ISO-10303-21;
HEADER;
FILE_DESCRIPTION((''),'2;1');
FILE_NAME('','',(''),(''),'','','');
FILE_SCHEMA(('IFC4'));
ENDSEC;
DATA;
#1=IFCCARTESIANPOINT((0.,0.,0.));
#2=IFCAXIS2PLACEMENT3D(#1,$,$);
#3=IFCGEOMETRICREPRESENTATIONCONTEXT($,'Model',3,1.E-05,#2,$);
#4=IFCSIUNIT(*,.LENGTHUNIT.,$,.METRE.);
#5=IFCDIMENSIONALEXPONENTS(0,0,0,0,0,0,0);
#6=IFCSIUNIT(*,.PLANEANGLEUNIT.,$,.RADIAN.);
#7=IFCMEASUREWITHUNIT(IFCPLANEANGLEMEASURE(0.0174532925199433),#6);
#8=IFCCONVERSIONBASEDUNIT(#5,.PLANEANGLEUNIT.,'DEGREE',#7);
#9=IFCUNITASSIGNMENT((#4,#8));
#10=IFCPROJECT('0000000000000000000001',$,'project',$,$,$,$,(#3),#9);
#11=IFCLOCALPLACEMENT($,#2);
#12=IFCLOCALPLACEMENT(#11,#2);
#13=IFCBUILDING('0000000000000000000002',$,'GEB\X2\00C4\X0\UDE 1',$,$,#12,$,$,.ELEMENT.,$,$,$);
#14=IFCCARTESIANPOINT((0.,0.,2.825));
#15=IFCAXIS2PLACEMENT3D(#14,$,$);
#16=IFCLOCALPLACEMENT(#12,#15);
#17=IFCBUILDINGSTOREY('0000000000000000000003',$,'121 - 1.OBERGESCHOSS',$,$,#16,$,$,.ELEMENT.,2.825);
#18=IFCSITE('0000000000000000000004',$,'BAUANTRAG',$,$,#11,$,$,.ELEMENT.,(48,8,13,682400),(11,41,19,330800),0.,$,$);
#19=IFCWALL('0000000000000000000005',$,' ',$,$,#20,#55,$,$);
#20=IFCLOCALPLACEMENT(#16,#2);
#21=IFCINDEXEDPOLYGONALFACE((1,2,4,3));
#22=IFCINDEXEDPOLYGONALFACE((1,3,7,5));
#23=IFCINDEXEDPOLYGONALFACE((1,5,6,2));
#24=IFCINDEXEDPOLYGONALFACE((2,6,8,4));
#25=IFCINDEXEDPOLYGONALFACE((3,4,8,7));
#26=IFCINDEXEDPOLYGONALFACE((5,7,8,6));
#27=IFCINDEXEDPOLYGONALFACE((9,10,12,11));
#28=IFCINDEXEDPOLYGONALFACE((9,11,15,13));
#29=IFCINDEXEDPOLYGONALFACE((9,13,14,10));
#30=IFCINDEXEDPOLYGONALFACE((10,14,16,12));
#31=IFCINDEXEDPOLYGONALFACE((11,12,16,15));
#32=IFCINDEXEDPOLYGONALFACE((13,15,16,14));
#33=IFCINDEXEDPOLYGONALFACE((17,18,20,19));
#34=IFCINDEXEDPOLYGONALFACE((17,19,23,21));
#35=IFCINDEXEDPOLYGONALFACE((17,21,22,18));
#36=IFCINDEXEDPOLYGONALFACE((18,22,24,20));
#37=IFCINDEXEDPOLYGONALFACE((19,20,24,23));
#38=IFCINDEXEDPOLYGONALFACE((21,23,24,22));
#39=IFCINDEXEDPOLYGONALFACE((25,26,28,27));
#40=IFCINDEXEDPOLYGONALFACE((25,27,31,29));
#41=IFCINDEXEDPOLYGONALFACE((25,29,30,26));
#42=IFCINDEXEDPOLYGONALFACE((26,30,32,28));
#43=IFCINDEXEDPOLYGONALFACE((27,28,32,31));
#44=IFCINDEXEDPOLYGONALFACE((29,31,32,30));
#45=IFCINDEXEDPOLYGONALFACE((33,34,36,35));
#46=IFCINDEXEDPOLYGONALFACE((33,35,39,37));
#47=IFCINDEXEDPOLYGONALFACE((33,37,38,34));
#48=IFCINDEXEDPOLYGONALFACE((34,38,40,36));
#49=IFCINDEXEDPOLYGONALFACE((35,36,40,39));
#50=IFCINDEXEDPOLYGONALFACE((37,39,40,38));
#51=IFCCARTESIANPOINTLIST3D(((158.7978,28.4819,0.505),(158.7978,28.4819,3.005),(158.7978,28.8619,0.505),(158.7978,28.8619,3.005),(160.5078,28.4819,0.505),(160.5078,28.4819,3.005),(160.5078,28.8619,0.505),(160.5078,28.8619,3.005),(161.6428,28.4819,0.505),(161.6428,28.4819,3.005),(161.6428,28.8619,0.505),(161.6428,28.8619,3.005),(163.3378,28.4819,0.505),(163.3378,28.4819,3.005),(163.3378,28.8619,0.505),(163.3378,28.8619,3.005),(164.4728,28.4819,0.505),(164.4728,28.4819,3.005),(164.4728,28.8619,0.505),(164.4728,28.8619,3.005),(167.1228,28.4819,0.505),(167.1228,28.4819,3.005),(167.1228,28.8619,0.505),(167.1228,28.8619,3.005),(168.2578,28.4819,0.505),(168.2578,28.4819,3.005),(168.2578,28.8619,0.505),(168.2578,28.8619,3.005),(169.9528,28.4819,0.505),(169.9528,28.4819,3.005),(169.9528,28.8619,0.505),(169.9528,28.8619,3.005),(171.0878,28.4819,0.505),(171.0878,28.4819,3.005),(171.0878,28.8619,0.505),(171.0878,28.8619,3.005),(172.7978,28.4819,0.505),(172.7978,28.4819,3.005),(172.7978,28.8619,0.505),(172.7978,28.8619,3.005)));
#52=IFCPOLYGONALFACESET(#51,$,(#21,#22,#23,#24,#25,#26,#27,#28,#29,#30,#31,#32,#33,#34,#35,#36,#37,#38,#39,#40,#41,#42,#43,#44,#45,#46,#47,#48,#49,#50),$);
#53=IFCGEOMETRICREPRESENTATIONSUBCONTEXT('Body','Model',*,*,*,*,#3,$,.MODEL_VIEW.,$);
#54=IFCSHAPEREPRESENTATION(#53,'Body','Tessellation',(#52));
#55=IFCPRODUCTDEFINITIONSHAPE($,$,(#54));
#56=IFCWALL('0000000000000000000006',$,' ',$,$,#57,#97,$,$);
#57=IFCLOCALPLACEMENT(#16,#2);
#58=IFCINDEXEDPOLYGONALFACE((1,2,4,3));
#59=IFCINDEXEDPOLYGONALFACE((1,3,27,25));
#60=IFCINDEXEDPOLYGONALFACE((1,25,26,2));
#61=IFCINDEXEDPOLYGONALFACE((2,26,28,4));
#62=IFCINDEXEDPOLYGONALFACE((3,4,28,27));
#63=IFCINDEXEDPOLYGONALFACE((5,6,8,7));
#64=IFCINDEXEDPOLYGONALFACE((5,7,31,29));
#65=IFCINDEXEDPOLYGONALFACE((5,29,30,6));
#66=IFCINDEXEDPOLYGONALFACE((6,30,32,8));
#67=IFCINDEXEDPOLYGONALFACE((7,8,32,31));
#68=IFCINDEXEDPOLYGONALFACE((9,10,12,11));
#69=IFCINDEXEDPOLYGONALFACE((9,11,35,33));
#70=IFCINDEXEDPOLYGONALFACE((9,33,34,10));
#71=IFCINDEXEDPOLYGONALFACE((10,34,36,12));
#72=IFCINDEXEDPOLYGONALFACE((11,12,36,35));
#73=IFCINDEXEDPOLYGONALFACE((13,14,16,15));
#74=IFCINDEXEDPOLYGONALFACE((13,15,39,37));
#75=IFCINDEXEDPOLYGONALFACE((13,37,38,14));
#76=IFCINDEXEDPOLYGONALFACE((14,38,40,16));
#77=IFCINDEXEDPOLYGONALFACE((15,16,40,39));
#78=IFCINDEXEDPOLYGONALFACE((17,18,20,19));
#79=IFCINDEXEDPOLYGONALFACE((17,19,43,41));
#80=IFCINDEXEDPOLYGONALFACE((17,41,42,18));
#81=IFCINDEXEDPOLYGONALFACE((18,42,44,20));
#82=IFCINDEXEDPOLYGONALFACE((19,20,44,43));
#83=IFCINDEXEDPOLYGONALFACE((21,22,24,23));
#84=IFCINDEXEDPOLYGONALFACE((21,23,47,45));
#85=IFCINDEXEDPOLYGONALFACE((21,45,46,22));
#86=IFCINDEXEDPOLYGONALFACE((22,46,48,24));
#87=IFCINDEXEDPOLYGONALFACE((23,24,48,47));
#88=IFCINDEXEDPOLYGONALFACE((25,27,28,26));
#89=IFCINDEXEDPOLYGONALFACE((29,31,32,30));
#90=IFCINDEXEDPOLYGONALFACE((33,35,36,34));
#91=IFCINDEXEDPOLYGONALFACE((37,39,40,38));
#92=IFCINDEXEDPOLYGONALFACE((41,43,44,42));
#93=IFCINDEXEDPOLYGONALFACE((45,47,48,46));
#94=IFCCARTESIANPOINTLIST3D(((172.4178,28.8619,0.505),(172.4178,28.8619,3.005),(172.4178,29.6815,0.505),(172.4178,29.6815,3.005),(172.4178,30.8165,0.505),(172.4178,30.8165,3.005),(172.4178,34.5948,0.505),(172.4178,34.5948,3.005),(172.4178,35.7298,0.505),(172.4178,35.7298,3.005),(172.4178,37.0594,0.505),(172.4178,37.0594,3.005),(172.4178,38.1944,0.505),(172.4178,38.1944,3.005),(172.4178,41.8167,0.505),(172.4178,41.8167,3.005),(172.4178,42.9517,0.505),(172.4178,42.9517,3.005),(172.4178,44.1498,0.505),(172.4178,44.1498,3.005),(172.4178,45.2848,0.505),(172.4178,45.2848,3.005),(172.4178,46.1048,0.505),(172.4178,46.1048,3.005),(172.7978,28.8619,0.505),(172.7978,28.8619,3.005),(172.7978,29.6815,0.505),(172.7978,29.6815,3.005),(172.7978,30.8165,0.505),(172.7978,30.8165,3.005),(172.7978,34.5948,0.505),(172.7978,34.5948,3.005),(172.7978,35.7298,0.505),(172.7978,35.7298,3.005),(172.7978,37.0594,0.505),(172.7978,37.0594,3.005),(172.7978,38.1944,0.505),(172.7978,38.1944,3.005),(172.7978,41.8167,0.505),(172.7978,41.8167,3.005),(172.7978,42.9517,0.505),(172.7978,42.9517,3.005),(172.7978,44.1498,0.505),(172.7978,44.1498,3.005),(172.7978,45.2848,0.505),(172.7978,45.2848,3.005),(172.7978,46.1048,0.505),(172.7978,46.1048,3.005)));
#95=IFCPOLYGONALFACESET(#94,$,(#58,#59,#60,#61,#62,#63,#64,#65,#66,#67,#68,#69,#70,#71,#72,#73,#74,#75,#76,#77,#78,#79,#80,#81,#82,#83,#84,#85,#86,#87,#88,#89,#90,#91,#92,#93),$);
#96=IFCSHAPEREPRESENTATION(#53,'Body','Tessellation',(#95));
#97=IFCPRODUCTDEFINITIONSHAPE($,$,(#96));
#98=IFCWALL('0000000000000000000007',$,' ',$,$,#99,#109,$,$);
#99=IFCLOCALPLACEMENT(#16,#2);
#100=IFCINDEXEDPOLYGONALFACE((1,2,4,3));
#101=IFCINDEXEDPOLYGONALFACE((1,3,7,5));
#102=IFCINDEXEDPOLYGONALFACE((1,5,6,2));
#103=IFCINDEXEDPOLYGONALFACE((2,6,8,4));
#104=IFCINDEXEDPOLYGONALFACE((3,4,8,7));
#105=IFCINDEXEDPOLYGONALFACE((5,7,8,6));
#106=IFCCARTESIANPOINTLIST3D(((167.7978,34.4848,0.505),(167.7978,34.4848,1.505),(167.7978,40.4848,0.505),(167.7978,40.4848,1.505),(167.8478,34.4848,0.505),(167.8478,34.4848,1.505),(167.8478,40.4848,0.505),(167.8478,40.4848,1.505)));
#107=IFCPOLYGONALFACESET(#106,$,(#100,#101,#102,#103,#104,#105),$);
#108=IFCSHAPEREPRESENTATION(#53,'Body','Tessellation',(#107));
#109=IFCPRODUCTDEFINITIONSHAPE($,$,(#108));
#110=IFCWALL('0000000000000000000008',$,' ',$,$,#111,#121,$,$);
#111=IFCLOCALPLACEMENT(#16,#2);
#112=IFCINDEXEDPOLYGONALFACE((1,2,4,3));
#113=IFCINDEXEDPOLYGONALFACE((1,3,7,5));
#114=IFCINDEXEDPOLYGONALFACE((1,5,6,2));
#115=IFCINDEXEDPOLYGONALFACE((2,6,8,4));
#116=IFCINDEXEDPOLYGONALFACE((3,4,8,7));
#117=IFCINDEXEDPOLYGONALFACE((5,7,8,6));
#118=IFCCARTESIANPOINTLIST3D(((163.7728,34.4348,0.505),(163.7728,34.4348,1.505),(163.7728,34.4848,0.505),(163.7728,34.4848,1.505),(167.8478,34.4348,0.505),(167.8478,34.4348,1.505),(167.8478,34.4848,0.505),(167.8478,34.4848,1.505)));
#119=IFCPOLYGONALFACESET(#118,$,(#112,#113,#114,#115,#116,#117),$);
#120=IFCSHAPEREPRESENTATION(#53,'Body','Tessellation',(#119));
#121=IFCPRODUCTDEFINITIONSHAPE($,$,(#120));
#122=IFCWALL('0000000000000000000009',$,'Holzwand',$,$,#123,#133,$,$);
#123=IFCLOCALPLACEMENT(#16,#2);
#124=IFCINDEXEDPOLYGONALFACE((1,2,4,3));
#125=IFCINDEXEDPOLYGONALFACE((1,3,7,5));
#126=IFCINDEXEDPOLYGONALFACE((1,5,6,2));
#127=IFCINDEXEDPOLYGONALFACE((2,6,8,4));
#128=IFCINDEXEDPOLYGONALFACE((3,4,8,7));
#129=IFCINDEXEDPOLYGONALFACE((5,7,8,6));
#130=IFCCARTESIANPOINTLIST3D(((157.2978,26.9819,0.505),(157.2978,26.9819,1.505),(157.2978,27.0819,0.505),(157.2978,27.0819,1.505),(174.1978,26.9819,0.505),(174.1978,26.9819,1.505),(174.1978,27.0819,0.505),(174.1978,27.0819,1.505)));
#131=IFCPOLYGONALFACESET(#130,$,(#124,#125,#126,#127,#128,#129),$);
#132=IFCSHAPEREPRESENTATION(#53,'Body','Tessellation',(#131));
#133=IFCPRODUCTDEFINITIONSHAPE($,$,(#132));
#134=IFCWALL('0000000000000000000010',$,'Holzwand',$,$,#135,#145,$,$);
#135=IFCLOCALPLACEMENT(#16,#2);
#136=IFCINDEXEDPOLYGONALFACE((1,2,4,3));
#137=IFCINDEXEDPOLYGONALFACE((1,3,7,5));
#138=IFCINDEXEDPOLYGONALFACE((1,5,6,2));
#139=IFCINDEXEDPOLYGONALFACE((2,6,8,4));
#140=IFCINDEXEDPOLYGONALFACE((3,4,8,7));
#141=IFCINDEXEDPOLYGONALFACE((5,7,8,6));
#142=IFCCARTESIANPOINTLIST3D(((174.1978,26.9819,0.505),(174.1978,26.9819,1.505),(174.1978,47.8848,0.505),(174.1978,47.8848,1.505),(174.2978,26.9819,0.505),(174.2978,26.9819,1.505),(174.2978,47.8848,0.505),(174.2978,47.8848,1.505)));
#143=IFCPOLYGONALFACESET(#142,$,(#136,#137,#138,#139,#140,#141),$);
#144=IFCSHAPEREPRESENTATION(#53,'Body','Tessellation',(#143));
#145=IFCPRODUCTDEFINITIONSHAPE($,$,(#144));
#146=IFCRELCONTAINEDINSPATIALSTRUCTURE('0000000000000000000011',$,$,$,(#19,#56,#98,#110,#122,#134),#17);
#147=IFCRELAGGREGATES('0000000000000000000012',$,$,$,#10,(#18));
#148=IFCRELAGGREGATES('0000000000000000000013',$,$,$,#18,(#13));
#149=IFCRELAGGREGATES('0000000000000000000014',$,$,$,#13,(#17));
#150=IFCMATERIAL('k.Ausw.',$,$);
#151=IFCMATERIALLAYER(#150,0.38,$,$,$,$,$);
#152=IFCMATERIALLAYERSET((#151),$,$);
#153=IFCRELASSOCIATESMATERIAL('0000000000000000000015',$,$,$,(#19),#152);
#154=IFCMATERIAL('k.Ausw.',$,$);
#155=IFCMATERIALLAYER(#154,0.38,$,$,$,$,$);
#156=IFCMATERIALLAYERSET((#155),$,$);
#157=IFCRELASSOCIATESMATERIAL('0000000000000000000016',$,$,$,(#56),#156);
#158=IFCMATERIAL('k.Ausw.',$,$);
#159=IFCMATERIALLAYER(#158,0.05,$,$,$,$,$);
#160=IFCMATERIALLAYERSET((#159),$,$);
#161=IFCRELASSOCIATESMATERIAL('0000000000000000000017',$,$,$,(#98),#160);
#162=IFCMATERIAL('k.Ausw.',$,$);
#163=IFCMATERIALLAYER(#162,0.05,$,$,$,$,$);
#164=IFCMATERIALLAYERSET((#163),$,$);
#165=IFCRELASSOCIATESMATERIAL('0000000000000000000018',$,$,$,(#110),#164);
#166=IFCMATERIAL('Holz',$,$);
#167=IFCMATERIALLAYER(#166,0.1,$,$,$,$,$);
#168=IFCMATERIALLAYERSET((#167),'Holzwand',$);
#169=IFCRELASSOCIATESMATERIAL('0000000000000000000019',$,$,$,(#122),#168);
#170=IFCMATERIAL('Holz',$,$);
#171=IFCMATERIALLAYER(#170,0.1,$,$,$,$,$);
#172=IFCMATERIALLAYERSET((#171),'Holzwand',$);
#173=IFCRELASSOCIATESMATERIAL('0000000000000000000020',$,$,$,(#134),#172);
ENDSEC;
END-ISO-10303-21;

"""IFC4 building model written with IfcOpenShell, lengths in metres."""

from ifc_helpers import new_model, entity, si_unit, converted_unit, frame, frame_2d, origin, origin_with_axes, place, context, subcontext, project, spatial, polyline, rectangle, outline, extrude, material, layer, layer_set, layer_usage, element, save


model = new_model("IFC4")

# Units and contexts
model_context = context("Model", 3, precision=1e-05, world=origin())
body_context = subcontext(model_context, "Body", "Model", "MODEL_VIEW")
ifc_project = project(units=[si_unit("LENGTHUNIT", "METRE"), converted_unit("PLANEANGLEUNIT", "DEGREE", entity("IfcPlaneAngleMeasure", 0.0174532925199433), si_unit("PLANEANGLEUNIT", "RADIAN"), dimensions=[0, 0, 0, 0, 0, 0, 0])], contexts=[model_context])

# Site, building, storey
site_placement = place(None, origin())
site = spatial("IfcSite", under=ifc_project, at=site_placement, Name="BAUANTRAG", CompositionType="ELEMENT", RefLatitude=(48, 8, 13, 682400), RefLongitude=(11, 41, 19, 330800), RefElevation=0.0)
building_placement = place(site_placement, origin())
building = spatial("IfcBuilding", under=site, at=building_placement, Name="GEBÄUDE 1", CompositionType="ELEMENT")
storey_placement = place(building_placement, frame((0.0, 0.0, 2.825)))
storey = spatial("IfcBuildingStorey", under=building, at=storey_placement, Name="121 - 1.OBERGESCHOSS", CompositionType="ELEMENT", Elevation=2.825)

# Walls, openings
ifc_material_1 = material(Name="k.Ausw.")
ifc_layer_1 = layer(ifc_material_1, 0.38)
ifc_layer_set_1 = layer_set([ifc_layer_1])
ifc_layer_usage_1 = layer_usage(ifc_layer_set_1, "AXIS2", "POSITIVE", 0.0)
wall_1_placement = place(storey_placement, frame((158.7978, 28.4819, 0.505), z_axis=(0.0, 0.0, 1.0), x_axis=(1.0, 0.0, 0.0)))
wall_1 = element("IfcWall", 1, at=wall_1_placement, inside=storey, material=ifc_layer_usage_1, Name=" ", context=body_context, shape_type="SweptSolid", body=[
    extrude(rectangle(XDim=14.0, YDim=0.38, at=frame_2d((7.0, 0.19), x_axis=(1.0, 0.0))), origin_with_axes(), (0.0, 0.0, 1.0), 2.5),
])
opening_1_placement = place(wall_1_placement, frame((5.675, 0.38, 0.0), z_axis=(0.0, -1.0, 0.0), x_axis=(0.0, 0.0, 1.0)))
element("IfcOpeningElement", 2, at=opening_1_placement, cuts=wall_1, ObjectType="Opening", context=body_context, shape_type="SweptSolid", body=[
    extrude(outline(polyline([(0.0, 1.135), (2.5, 1.135), (2.5, 0.0), (0.0, 0.0), (0.0, 1.135)])), origin_with_axes(), (0.0, 0.0, 1.0), 0.38),
])
opening_2_placement = place(wall_1_placement, frame((9.46, 0.38, 0.0), z_axis=(0.0, -1.0, 0.0), x_axis=(0.0, 0.0, 1.0)))
element("IfcOpeningElement", 3, at=opening_2_placement, cuts=wall_1, ObjectType="Opening", context=body_context, shape_type="SweptSolid", body=[
    extrude(outline(polyline([(0.0, 1.135), (2.5, 1.135), (2.5, 0.0), (0.0, 0.0), (0.0, 1.135)])), origin_with_axes(), (0.0, 0.0, 1.0), 0.38),
])
opening_3_placement = place(wall_1_placement, frame((2.845, 0.38, 0.0), z_axis=(0.0, -1.0, 0.0), x_axis=(0.0, 0.0, 1.0)))
element("IfcOpeningElement", 4, at=opening_3_placement, cuts=wall_1, ObjectType="Opening", context=body_context, shape_type="SweptSolid", body=[
    extrude(outline(polyline([(0.0, 1.135), (2.5, 1.135), (2.5, 0.0), (0.0, 0.0), (0.0, 1.135)])), origin_with_axes(), (0.0, 0.0, 1.0), 0.38),
])
opening_4_placement = place(wall_1_placement, frame((12.29, 0.38, 0.0), z_axis=(0.0, -1.0, 0.0), x_axis=(0.0, 0.0, 1.0)))
element("IfcOpeningElement", 5, at=opening_4_placement, cuts=wall_1, ObjectType="Opening", context=body_context, shape_type="SweptSolid", body=[
    extrude(outline(polyline([(0.0, 1.135), (2.5, 1.135), (2.5, 0.0), (0.0, 0.0), (0.0, 1.135)])), origin_with_axes(), (0.0, 0.0, 1.0), 0.38),
])
ifc_material_2 = material(Name="k.Ausw.")
ifc_layer_2 = layer(ifc_material_2, 0.38)
ifc_layer_set_2 = layer_set([ifc_layer_2])
ifc_layer_usage_2 = layer_usage(ifc_layer_set_2, "AXIS2", "POSITIVE", 0.0)
wall_2_placement = place(storey_placement, frame((172.7978, 28.8619, 0.505), z_axis=(0.0, 0.0, 1.0), x_axis=(0.0, 1.0, 0.0)))
wall_2 = element("IfcWall", 6, at=wall_2_placement, inside=storey, material=ifc_layer_usage_2, Name=" ", context=body_context, shape_type="SweptSolid", body=[
    extrude(rectangle(XDim=17.2429, YDim=0.38, at=frame_2d((8.6214, 0.19), x_axis=(1.0, 0.0))), origin_with_axes(), (0.0, 0.0, 1.0), 2.5),
])
opening_5_placement = place(wall_2_placement, frame((9.3325, 0.38, 0.0), z_axis=(0.0, -1.0, 0.0), x_axis=(0.0, 0.0, 1.0)))
element("IfcOpeningElement", 7, at=opening_5_placement, cuts=wall_2, ObjectType="Opening", context=body_context, shape_type="SweptSolid", body=[
    extrude(outline(polyline([(0.0, 1.135), (2.5, 1.135), (2.5, 0.0), (0.0, 0.0), (0.0, 1.135)])), origin_with_axes(), (0.0, 0.0, 1.0), 0.38),
])
opening_6_placement = place(wall_2_placement, frame((6.8679, 0.38, 0.0), z_axis=(0.0, -1.0, 0.0), x_axis=(0.0, 0.0, 1.0)))
element("IfcOpeningElement", 8, at=opening_6_placement, cuts=wall_2, ObjectType="Opening", context=body_context, shape_type="SweptSolid", body=[
    extrude(outline(polyline([(0.0, 1.135), (2.5, 1.135), (2.5, 0.0), (0.0, 0.0), (0.0, 1.135)])), origin_with_axes(), (0.0, 0.0, 1.0), 0.38),
])
opening_7_placement = place(wall_2_placement, frame((1.9546, 0.38, 0.0), z_axis=(0.0, -1.0, 0.0), x_axis=(0.0, 0.0, 1.0)))
element("IfcOpeningElement", 9, at=opening_7_placement, cuts=wall_2, ObjectType="Opening", context=body_context, shape_type="SweptSolid", body=[
    extrude(outline(polyline([(0.0, 1.135), (2.5, 1.135), (2.5, 0.0), (0.0, 0.0), (0.0, 1.135)])), origin_with_axes(), (0.0, 0.0, 1.0), 0.38),
])
opening_8_placement = place(wall_2_placement, frame((16.4229, 0.38, 0.0), z_axis=(0.0, -1.0, 0.0), x_axis=(0.0, 0.0, 1.0)))
element("IfcOpeningElement", 10, at=opening_8_placement, cuts=wall_2, ObjectType="Opening", context=body_context, shape_type="SweptSolid", body=[
    extrude(outline(polyline([(0.0, 1.135), (2.5, 1.135), (2.5, 0.0), (0.0, 0.0), (0.0, 1.135)])), origin_with_axes(), (0.0, 0.0, 1.0), 0.38),
])
opening_9_placement = place(wall_2_placement, frame((14.0898, 0.38, 0.0), z_axis=(0.0, -1.0, 0.0), x_axis=(0.0, 0.0, 1.0)))
element("IfcOpeningElement", 11, at=opening_9_placement, cuts=wall_2, ObjectType="Opening", context=body_context, shape_type="SweptSolid", body=[
    extrude(outline(polyline([(0.0, 1.135), (2.5, 1.135), (2.5, 0.0), (0.0, 0.0), (0.0, 1.135)])), origin_with_axes(), (0.0, 0.0, 1.0), 0.38),
])

# Walls
ifc_material_3 = material(Name="k.Ausw.")
ifc_layer_3 = layer(ifc_material_3, 0.05)
ifc_layer_set_3 = layer_set([ifc_layer_3])
ifc_layer_usage_3 = layer_usage(ifc_layer_set_3, "AXIS2", "POSITIVE", 0.0)
wall_3_placement = place(storey_placement, frame((167.8478, 34.4848, 0.505), z_axis=(0.0, 0.0, 1.0), x_axis=(0.0, 1.0, 0.0)))
element("IfcWall", 12, at=wall_3_placement, inside=storey, material=ifc_layer_usage_3, Name=" ", context=body_context, shape_type="SweptSolid", body=[
    extrude(rectangle(XDim=6.0, YDim=0.05, at=frame_2d((3.0, 0.025), x_axis=(1.0, 0.0))), origin_with_axes(), (0.0, 0.0, 1.0), 1.0),
])
ifc_material_4 = material(Name="k.Ausw.")
ifc_layer_4 = layer(ifc_material_4, 0.05)
ifc_layer_set_4 = layer_set([ifc_layer_4])
ifc_layer_usage_4 = layer_usage(ifc_layer_set_4, "AXIS2", "POSITIVE", 0.0)
wall_4_placement = place(storey_placement, frame((163.7728, 34.4348, 0.505), z_axis=(0.0, 0.0, 1.0), x_axis=(1.0, 0.0, 0.0)))
element("IfcWall", 13, at=wall_4_placement, inside=storey, material=ifc_layer_usage_4, Name=" ", context=body_context, shape_type="SweptSolid", body=[
    extrude(rectangle(XDim=4.075, YDim=0.05, at=frame_2d((2.0375, 0.025), x_axis=(1.0, 0.0))), origin_with_axes(), (0.0, 0.0, 1.0), 1.0),
])
ifc_material_5 = material(Name="Holz")
ifc_layer_5 = layer(ifc_material_5, 0.1)
ifc_layer_set_5 = layer_set([ifc_layer_5], Name="Holzwand")
ifc_layer_usage_5 = layer_usage(ifc_layer_set_5, "AXIS2", "POSITIVE", 0.0)
wall_5_placement = place(storey_placement, frame((157.2978, 26.9819, 0.505)))
element("IfcWall", 14, at=wall_5_placement, inside=storey, material=ifc_layer_usage_5, Name="Holzwand", context=body_context, shape_type="SweptSolid", body=[
    extrude(rectangle(XDim=16.9, YDim=0.1, at=frame_2d((8.45, 0.05), x_axis=(1.0, 0.0))), origin_with_axes(), (0.0, 0.0, 1.0), 1.0),
])
ifc_material_6 = material(Name="Holz")
ifc_layer_6 = layer(ifc_material_6, 0.1)
ifc_layer_set_6 = layer_set([ifc_layer_6], Name="Holzwand")
ifc_layer_usage_6 = layer_usage(ifc_layer_set_6, "AXIS2", "POSITIVE", 0.0)
wall_6_placement = place(storey_placement, frame((174.2978, 26.9819, 0.505), z_axis=(0.0, 0.0, 1.0), x_axis=(0.0, 1.0, 0.0)))
element("IfcWall", 15, at=wall_6_placement, inside=storey, material=ifc_layer_usage_6, Name="Holzwand", context=body_context, shape_type="SweptSolid", body=[
    extrude(rectangle(XDim=20.9029, YDim=0.1, at=frame_2d((10.4514, 0.05), x_axis=(1.0, 0.0))), origin_with_axes(), (0.0, 0.0, 1.0), 1.0),
])

save(model, "model.ifc")
